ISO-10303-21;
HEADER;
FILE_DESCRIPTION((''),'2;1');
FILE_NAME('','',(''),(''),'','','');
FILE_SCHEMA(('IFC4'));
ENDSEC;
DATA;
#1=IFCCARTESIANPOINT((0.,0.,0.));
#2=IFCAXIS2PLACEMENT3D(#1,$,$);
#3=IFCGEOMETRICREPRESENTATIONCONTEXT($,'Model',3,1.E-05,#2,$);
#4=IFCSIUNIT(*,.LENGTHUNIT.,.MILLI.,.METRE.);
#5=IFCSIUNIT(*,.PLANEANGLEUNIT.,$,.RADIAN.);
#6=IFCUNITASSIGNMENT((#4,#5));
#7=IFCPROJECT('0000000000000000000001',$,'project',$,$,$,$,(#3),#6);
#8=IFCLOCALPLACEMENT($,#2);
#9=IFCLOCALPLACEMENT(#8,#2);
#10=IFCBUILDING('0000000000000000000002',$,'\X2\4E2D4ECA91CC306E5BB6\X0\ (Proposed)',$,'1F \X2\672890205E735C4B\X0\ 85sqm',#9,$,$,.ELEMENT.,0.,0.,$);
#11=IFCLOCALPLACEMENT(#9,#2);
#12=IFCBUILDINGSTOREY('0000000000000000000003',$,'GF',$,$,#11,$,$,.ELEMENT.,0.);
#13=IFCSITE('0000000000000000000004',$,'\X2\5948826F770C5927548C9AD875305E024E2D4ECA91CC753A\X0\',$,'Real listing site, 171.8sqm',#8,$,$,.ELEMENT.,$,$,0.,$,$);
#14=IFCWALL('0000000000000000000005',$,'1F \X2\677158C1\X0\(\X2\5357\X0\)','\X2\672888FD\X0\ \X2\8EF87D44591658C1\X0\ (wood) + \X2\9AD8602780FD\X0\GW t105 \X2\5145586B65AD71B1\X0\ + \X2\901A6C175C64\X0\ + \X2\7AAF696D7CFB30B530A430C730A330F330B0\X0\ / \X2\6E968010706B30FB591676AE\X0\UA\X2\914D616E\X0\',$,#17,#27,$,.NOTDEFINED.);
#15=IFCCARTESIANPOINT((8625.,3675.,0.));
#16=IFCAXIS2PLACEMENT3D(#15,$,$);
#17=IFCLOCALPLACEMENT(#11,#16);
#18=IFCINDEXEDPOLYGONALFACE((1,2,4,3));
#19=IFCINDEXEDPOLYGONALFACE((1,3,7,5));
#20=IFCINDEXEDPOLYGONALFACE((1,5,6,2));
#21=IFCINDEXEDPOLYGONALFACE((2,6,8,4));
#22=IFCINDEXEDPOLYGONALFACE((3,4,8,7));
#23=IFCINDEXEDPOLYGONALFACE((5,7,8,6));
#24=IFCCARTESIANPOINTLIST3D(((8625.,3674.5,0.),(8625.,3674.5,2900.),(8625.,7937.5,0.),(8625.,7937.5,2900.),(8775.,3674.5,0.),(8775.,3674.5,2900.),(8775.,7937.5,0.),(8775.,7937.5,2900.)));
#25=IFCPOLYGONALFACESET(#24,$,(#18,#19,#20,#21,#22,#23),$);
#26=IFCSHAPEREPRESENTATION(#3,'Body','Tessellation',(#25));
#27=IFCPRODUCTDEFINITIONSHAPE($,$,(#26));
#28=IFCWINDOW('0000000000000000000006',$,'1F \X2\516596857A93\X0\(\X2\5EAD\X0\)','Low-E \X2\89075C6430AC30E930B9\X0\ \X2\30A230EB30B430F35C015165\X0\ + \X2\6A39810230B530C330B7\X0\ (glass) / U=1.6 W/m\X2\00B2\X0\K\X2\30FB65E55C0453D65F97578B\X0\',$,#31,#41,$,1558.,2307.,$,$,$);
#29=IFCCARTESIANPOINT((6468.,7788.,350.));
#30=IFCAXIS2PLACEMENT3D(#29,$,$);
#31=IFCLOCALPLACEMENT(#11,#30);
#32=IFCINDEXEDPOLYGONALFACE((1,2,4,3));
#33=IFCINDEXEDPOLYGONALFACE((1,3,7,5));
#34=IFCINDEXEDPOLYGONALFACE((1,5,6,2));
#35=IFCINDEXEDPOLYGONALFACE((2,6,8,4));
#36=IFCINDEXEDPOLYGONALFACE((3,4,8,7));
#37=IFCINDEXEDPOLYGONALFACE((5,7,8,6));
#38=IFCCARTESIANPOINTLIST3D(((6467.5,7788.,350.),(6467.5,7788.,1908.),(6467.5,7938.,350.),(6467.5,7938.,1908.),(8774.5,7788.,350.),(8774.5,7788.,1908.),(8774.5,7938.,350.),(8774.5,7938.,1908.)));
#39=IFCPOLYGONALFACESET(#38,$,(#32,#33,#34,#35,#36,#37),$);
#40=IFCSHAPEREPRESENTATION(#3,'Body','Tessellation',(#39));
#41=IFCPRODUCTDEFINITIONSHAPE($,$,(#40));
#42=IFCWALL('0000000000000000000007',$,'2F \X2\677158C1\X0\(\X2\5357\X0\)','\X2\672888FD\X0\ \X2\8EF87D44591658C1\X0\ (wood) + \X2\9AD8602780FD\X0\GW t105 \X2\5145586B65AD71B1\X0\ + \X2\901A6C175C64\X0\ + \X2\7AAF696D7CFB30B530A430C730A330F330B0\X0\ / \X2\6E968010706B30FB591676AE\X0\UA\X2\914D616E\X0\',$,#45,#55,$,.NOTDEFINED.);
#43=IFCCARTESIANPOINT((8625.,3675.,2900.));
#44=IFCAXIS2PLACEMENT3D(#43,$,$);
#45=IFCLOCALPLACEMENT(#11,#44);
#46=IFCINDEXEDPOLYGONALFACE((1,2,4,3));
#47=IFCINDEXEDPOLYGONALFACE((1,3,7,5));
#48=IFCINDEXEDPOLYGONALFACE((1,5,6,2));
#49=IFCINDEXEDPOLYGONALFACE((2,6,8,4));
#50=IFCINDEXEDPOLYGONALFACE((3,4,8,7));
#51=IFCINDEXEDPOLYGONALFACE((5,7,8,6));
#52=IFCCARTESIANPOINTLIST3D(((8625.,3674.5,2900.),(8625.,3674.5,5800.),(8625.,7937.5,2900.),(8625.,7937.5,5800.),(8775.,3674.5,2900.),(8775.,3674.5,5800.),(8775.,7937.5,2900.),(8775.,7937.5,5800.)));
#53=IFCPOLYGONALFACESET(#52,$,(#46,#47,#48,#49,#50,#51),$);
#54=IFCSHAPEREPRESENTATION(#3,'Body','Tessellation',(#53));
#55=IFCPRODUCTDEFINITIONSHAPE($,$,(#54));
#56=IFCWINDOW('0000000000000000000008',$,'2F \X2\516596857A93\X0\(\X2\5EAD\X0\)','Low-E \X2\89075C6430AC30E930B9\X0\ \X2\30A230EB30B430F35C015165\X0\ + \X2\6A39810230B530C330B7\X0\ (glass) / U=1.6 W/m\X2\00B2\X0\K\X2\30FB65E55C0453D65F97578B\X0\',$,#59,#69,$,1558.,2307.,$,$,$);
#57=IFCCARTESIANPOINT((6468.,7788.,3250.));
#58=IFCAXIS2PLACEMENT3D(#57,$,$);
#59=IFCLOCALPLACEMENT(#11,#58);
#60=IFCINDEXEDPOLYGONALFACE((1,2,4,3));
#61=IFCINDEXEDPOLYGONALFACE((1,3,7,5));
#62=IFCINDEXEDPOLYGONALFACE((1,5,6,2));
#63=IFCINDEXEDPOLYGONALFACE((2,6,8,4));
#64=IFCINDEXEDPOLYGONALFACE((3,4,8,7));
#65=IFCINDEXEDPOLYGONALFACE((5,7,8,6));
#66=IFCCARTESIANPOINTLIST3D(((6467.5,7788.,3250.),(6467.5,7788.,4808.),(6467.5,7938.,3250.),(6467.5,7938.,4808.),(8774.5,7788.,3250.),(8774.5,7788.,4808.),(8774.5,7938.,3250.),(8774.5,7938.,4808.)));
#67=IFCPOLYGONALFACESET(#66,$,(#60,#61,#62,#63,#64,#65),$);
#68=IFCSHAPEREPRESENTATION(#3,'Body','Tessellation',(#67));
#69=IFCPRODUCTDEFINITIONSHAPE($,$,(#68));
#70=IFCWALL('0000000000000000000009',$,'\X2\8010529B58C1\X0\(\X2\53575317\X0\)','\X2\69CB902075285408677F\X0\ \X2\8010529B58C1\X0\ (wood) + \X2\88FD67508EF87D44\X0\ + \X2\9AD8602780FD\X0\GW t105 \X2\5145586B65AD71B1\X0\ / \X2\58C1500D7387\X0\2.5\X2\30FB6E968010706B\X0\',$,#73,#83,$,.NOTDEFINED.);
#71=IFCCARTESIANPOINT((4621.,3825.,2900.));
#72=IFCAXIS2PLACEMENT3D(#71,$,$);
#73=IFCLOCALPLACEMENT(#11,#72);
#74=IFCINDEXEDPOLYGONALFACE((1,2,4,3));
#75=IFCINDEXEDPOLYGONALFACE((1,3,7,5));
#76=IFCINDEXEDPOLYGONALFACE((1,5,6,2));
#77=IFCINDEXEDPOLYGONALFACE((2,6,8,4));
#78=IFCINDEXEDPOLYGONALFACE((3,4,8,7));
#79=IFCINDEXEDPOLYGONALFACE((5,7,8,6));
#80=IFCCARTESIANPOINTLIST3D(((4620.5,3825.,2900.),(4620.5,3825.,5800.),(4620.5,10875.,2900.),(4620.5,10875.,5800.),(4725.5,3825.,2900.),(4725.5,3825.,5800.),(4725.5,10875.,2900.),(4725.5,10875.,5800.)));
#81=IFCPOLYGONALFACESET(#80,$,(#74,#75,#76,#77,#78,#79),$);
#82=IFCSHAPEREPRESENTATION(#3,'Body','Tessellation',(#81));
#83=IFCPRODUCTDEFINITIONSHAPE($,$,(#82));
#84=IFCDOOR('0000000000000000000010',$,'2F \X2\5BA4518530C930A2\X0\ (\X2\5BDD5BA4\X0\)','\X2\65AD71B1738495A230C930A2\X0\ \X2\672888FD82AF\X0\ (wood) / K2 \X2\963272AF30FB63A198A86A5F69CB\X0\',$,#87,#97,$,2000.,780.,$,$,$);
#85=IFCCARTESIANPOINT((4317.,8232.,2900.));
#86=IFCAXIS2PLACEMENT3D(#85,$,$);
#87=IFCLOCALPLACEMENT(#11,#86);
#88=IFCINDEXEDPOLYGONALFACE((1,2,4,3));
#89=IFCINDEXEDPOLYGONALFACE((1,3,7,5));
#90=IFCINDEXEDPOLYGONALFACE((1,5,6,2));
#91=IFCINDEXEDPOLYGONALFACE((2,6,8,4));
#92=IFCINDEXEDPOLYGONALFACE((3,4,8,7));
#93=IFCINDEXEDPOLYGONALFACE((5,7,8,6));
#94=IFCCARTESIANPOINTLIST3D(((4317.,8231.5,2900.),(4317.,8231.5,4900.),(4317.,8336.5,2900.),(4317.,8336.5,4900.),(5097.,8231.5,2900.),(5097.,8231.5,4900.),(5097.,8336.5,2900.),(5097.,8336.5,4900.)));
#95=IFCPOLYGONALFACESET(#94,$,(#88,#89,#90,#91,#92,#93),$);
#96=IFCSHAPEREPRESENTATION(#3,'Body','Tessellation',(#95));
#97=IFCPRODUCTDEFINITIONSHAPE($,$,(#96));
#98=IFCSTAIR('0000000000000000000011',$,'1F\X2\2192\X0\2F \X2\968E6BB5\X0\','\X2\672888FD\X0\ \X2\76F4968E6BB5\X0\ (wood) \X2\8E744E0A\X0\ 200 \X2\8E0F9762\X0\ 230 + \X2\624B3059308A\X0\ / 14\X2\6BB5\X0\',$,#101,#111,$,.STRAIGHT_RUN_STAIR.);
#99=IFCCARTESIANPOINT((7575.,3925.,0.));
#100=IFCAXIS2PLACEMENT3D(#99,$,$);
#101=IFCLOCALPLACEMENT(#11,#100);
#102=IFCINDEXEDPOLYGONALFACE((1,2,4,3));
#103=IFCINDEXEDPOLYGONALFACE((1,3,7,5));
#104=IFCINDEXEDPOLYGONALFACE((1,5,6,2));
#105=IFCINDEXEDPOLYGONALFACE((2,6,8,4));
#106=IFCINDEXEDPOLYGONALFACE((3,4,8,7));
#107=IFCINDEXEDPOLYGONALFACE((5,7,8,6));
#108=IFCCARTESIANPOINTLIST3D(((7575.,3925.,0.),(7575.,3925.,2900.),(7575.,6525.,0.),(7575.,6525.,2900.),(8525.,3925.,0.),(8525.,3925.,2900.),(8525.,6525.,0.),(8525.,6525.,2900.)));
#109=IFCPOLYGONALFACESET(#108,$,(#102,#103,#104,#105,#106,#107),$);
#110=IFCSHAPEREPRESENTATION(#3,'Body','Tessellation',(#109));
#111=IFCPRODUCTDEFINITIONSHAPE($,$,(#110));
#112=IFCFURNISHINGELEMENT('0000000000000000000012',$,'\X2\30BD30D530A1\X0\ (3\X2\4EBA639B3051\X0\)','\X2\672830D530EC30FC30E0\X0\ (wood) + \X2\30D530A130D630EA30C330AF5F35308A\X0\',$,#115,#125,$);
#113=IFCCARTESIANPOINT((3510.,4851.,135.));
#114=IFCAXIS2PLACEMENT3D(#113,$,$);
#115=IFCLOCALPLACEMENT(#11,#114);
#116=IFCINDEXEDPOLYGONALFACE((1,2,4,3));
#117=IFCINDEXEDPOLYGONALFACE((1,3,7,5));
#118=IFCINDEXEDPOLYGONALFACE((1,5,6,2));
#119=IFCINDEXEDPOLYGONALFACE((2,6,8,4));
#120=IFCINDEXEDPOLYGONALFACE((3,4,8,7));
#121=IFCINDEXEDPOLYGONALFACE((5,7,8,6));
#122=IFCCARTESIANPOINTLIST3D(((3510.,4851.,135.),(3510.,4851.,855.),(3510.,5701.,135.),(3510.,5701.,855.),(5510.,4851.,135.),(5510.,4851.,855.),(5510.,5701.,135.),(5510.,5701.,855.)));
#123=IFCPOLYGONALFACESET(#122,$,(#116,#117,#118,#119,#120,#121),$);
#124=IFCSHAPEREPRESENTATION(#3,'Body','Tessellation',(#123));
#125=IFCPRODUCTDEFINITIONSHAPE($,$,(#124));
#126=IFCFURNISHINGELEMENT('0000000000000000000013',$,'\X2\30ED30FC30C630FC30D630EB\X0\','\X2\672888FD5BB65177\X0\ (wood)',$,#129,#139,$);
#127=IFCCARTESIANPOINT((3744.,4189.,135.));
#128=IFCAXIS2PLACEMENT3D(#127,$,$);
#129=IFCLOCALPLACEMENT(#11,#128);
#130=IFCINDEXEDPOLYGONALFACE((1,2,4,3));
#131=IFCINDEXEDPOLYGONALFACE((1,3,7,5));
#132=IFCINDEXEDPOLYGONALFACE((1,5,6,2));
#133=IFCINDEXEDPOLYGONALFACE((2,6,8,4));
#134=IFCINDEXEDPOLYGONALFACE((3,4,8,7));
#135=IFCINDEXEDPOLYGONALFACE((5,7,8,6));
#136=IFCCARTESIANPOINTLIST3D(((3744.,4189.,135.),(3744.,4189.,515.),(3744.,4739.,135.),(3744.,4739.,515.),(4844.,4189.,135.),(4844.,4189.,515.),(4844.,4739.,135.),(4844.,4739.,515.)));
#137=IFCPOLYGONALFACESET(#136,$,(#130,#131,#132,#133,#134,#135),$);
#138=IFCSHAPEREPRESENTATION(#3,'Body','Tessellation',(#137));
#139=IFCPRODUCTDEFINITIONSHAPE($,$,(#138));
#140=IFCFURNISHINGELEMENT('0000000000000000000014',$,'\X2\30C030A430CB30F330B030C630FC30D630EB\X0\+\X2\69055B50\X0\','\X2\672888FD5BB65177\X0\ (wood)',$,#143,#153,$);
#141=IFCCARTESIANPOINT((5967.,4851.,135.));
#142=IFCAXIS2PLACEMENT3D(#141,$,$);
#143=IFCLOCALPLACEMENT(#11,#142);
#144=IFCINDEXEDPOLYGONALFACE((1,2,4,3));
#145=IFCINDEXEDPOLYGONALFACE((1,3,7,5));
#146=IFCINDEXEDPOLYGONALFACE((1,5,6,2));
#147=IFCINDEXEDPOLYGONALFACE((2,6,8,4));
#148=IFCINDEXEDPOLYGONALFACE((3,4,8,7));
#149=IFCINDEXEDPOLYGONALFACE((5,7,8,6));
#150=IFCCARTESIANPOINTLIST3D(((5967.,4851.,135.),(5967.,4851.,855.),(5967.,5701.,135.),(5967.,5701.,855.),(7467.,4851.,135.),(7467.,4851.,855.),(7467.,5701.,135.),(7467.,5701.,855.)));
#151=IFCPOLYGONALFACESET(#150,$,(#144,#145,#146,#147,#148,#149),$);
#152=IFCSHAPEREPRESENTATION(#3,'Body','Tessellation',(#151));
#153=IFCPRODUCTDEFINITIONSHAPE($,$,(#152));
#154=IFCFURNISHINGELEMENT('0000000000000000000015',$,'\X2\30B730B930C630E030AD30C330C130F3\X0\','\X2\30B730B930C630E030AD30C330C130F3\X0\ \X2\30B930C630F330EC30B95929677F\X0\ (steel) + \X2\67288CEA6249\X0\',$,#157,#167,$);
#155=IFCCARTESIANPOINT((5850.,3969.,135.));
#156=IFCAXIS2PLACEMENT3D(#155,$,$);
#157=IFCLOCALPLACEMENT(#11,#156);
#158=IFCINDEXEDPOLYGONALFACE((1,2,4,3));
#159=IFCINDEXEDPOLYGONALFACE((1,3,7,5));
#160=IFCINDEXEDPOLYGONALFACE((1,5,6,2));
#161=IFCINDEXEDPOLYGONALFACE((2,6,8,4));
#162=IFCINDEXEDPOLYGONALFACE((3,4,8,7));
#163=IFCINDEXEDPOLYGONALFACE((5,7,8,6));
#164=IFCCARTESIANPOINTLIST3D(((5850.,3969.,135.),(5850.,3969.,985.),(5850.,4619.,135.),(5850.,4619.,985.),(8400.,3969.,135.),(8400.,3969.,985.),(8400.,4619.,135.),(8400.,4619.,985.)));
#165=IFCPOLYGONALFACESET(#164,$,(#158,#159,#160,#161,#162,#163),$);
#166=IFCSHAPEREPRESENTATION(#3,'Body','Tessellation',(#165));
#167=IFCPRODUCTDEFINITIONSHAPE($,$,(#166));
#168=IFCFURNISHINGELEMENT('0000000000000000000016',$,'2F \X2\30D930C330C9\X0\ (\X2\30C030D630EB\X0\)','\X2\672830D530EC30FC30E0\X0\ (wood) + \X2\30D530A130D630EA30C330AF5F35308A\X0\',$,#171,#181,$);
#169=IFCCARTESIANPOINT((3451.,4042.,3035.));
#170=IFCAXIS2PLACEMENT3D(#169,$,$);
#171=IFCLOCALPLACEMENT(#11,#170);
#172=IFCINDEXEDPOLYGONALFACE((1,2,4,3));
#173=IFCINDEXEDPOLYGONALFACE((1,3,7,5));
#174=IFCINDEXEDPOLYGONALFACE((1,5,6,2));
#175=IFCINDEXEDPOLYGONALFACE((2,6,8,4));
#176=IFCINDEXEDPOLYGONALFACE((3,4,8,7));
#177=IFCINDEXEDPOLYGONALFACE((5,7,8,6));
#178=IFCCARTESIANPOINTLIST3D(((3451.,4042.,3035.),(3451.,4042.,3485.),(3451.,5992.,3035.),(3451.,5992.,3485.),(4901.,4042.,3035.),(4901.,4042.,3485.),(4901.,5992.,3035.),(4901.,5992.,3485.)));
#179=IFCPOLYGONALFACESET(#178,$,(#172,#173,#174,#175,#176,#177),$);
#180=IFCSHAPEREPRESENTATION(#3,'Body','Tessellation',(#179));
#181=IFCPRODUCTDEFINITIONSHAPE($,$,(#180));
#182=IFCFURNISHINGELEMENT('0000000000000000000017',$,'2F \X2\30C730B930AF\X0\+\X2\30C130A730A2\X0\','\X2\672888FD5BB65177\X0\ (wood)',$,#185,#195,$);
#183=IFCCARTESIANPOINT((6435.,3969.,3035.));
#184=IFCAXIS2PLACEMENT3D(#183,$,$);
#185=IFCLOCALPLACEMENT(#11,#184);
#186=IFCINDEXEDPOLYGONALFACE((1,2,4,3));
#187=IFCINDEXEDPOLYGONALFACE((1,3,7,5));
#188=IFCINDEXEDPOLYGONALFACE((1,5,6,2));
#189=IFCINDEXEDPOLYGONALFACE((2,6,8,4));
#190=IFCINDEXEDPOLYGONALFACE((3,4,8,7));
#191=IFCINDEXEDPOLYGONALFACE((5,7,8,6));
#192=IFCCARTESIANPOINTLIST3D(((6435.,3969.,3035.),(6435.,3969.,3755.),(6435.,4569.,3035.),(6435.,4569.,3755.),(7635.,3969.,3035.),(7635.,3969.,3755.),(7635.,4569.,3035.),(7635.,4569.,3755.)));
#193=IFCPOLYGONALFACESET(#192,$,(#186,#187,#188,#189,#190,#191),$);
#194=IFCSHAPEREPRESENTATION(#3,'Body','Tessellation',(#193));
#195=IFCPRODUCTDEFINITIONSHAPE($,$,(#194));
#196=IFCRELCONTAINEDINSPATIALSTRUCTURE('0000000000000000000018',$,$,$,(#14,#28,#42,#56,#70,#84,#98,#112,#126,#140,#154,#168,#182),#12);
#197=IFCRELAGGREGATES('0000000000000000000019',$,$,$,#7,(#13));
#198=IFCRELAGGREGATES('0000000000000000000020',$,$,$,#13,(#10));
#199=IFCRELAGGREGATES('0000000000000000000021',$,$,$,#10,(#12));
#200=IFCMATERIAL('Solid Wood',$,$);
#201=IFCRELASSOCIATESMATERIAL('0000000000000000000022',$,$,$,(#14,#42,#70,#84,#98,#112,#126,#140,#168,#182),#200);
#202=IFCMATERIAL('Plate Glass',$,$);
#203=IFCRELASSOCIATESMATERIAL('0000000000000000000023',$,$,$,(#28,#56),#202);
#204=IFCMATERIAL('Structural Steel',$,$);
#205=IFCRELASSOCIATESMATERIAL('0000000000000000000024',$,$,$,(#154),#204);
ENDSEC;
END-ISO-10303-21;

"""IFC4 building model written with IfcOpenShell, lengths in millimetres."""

from ifc_helpers import new_model, si_unit, frame, frame_2d, origin, place, context, project, spatial, rectangle, extrude, material, element, fill, save


model = new_model("IFC4")

# Units and contexts
model_context = context("Model", 3, precision=1e-05, world=origin())
ifc_project = project(units=[si_unit("LENGTHUNIT", "METRE", prefix="MILLI"), si_unit("PLANEANGLEUNIT", "RADIAN")], contexts=[model_context])

# Site, building, storey
site_placement = place(None, origin())
site = spatial("IfcSite", under=ifc_project, at=site_placement, Name="奈良県大和高田市中今里町", ObjectType="Real listing site, 171.8sqm", CompositionType="ELEMENT", RefElevation=0.0)
building_placement = place(site_placement, origin())
building = spatial("IfcBuilding", under=site, at=building_placement, Name="中今里の家 (Proposed)", ObjectType="1F 木造平屋 85sqm", CompositionType="ELEMENT", ElevationOfRefHeight=0.0, ElevationOfTerrain=0.0)
storey_placement = place(building_placement, origin())
storey = spatial("IfcBuildingStorey", under=building, at=storey_placement, Name="GF", CompositionType="ELEMENT", Elevation=0.0)

# Wall, opening, window
ifc_material_1 = material(Name="Solid Wood")
wall_1_placement = place(storey_placement, frame((8625.0, 3675.0, 0.0)))
wall_1 = element("IfcWall", 1, at=wall_1_placement, inside=storey, material=ifc_material_1, Name="1F 東壁(南)", Description="木製 軸組外壁 (wood) + 高性能GW t105 充填断熱 + 通気層 + 窯業系サイディング / 準耐火・外皮UA配慮", PredefinedType="NOTDEFINED", context=model_context, shape_type="SweptSolid", body=[
    extrude(rectangle(XDim=150.0, YDim=4263.0, at=frame_2d((75.0, 2131.0))), frame((8625.0, 3675.0, 0.0)), (0.0, 0.0, 1.0), 2900.0),
])
opening_1_placement = place(storey_placement, frame((6468.0, 7788.0, 350.0)))
opening_1 = element("IfcOpeningElement", 2, at=opening_1_placement, cuts=wall_1, PredefinedType="NOTDEFINED", context=model_context, shape_type="SweptSolid", body=[
    extrude(rectangle(XDim=2307.0, YDim=150.0, at=frame_2d((1153.0, 75.0))), frame((6468.0, 7788.0, 350.0)), (0.0, 0.0, 1.0), 1558.0),
])
ifc_material_2 = material(Name="Plate Glass")
window_1_placement = place(storey_placement, frame((6468.0, 7788.0, 350.0)))
window_1 = element("IfcWindow", 3, at=window_1_placement, inside=storey, material=ifc_material_2, Name="1F 入隅窓(庭)", Description="Low-E 複層ガラス アルゴン封入 + 樹脂サッシ (glass) / U=1.6 W/m²K・日射取得型", OverallHeight=1558.0, OverallWidth=2307.0, context=model_context, shape_type="SweptSolid", body=[
    extrude(rectangle(XDim=2307.0, YDim=150.0, at=frame_2d((1153.0, 75.0))), frame((6468.0, 7788.0, 350.0)), (0.0, 0.0, 1.0), 1558.0),
])
fill(opening_1, window_1)

# Wall, opening, window
wall_2_placement = place(storey_placement, frame((8625.0, 3675.0, 2900.0)))
wall_2 = element("IfcWall", 4, at=wall_2_placement, inside=storey, material=ifc_material_1, Name="2F 東壁(南)", Description="木製 軸組外壁 (wood) + 高性能GW t105 充填断熱 + 通気層 + 窯業系サイディング / 準耐火・外皮UA配慮", PredefinedType="NOTDEFINED", context=model_context, shape_type="SweptSolid", body=[
    extrude(rectangle(XDim=150.0, YDim=4263.0, at=frame_2d((75.0, 2131.0))), frame((8625.0, 3675.0, 2900.0)), (0.0, 0.0, 1.0), 2900.0),
])
opening_2_placement = place(storey_placement, frame((6468.0, 7788.0, 3250.0)))
opening_2 = element("IfcOpeningElement", 5, at=opening_2_placement, cuts=wall_2, PredefinedType="NOTDEFINED", context=model_context, shape_type="SweptSolid", body=[
    extrude(rectangle(XDim=2307.0, YDim=150.0, at=frame_2d((1153.0, 75.0))), frame((6468.0, 7788.0, 3250.0)), (0.0, 0.0, 1.0), 1558.0),
])
window_2_placement = place(storey_placement, frame((6468.0, 7788.0, 3250.0)))
window_2 = element("IfcWindow", 6, at=window_2_placement, inside=storey, material=ifc_material_2, Name="2F 入隅窓(庭)", Description="Low-E 複層ガラス アルゴン封入 + 樹脂サッシ (glass) / U=1.6 W/m²K・日射取得型", OverallHeight=1558.0, OverallWidth=2307.0, context=model_context, shape_type="SweptSolid", body=[
    extrude(rectangle(XDim=2307.0, YDim=150.0, at=frame_2d((1153.0, 75.0))), frame((6468.0, 7788.0, 3250.0)), (0.0, 0.0, 1.0), 1558.0),
])
fill(opening_2, window_2)

# Wall, opening, door
wall_3_placement = place(storey_placement, frame((4621.0, 3825.0, 2900.0)))
wall_3 = element("IfcWall", 7, at=wall_3_placement, inside=storey, material=ifc_material_1, Name="耐力壁(南北)", Description="構造用合板 耐力壁 (wood) + 製材軸組 + 高性能GW t105 充填断熱 / 壁倍率2.5・準耐火", PredefinedType="NOTDEFINED", context=model_context, shape_type="SweptSolid", body=[
    extrude(rectangle(XDim=105.0, YDim=7050.0, at=frame_2d((52.0, 3525.0))), frame((4621.0, 3825.0, 2900.0)), (0.0, 0.0, 1.0), 2900.0),
])
opening_3_placement = place(storey_placement, frame((4317.0, 8232.0, 2900.0)))
opening_3 = element("IfcOpeningElement", 8, at=opening_3_placement, cuts=wall_3, PredefinedType="NOTDEFINED", context=model_context, shape_type="SweptSolid", body=[
    extrude(rectangle(XDim=780.0, YDim=105.0, at=frame_2d((390.0, 52.0))), frame((4317.0, 8232.0, 2900.0)), (0.0, 0.0, 1.0), 2000.0),
])
door_1_placement = place(storey_placement, frame((4317.0, 8232.0, 2900.0)))
door_1 = element("IfcDoor", 9, at=door_1_placement, inside=storey, material=ifc_material_1, Name="2F 室内ドア (寝室)", Description="断熱玄関ドア 木製芯 (wood) / K2 防犯・採風機構", OverallHeight=2000.0, OverallWidth=780.0, context=model_context, shape_type="SweptSolid", body=[
    extrude(rectangle(XDim=780.0, YDim=105.0, at=frame_2d((390.0, 52.0))), frame((4317.0, 8232.0, 2900.0)), (0.0, 0.0, 1.0), 2000.0),
])
fill(opening_3, door_1)

# Stair
stair_placement = place(storey_placement, frame((7575.0, 3925.0, 0.0)))
element("IfcStair", 10, at=stair_placement, inside=storey, material=ifc_material_1, Name="1F→2F 階段", Description="木製 直階段 (wood) 蹴上 200 踏面 230 + 手すり / 14段", PredefinedType="STRAIGHT_RUN_STAIR", context=model_context, shape_type="SweptSolid", body=[
    extrude(rectangle(XDim=950.0, YDim=2600.0, at=frame_2d((475.0, 1300.0))), frame((7575.0, 3925.0, 0.0)), (0.0, 0.0, 1.0), 2900.0),
])

# Furnishing elements
furnishing_1_placement = place(storey_placement, frame((3510.0, 4851.0, 135.0)))
element("IfcFurnishingElement", 11, at=furnishing_1_placement, inside=storey, material=ifc_material_1, Name="ソファ (3人掛け)", Description="木フレーム (wood) + ファブリック張り", context=model_context, shape_type="SweptSolid", body=[
    extrude(rectangle(XDim=2000.0, YDim=850.0, at=frame_2d((1000.0, 425.0))), frame((3510.0, 4851.0, 135.0)), (0.0, 0.0, 1.0), 720.0),
])
furnishing_2_placement = place(storey_placement, frame((3744.0, 4189.0, 135.0)))
element("IfcFurnishingElement", 12, at=furnishing_2_placement, inside=storey, material=ifc_material_1, Name="ローテーブル", Description="木製家具 (wood)", context=model_context, shape_type="SweptSolid", body=[
    extrude(rectangle(XDim=1100.0, YDim=550.0, at=frame_2d((550.0, 275.0))), frame((3744.0, 4189.0, 135.0)), (0.0, 0.0, 1.0), 380.0),
])
furnishing_3_placement = place(storey_placement, frame((5967.0, 4851.0, 135.0)))
element("IfcFurnishingElement", 13, at=furnishing_3_placement, inside=storey, material=ifc_material_1, Name="ダイニングテーブル+椅子", Description="木製家具 (wood)", context=model_context, shape_type="SweptSolid", body=[
    extrude(rectangle(XDim=1500.0, YDim=850.0, at=frame_2d((750.0, 425.0))), frame((5967.0, 4851.0, 135.0)), (0.0, 0.0, 1.0), 720.0),
])
ifc_material_3 = material(Name="Structural Steel")
furnishing_4_placement = place(storey_placement, frame((5850.0, 3969.0, 135.0)))
element("IfcFurnishingElement", 14, at=furnishing_4_placement, inside=storey, material=ifc_material_3, Name="システムキッチン", Description="システムキッチン ステンレス天板 (steel) + 木質扉", context=model_context, shape_type="SweptSolid", body=[
    extrude(rectangle(XDim=2550.0, YDim=650.0, at=frame_2d((1275.0, 325.0))), frame((5850.0, 3969.0, 135.0)), (0.0, 0.0, 1.0), 850.0),
])
furnishing_5_placement = place(storey_placement, frame((3451.0, 4042.0, 3035.0)))
element("IfcFurnishingElement", 15, at=furnishing_5_placement, inside=storey, material=ifc_material_1, Name="2F ベッド (ダブル)", Description="木フレーム (wood) + ファブリック張り", context=model_context, shape_type="SweptSolid", body=[
    extrude(rectangle(XDim=1450.0, YDim=1950.0, at=frame_2d((725.0, 975.0))), frame((3451.0, 4042.0, 3035.0)), (0.0, 0.0, 1.0), 450.0),
])
furnishing_6_placement = place(storey_placement, frame((6435.0, 3969.0, 3035.0)))
element("IfcFurnishingElement", 16, at=furnishing_6_placement, inside=storey, material=ifc_material_1, Name="2F デスク+チェア", Description="木製家具 (wood)", context=model_context, shape_type="SweptSolid", body=[
    extrude(rectangle(XDim=1200.0, YDim=600.0, at=frame_2d((600.0, 300.0))), frame((6435.0, 3969.0, 3035.0)), (0.0, 0.0, 1.0), 720.0),
])

save(model, "model.ifc")
